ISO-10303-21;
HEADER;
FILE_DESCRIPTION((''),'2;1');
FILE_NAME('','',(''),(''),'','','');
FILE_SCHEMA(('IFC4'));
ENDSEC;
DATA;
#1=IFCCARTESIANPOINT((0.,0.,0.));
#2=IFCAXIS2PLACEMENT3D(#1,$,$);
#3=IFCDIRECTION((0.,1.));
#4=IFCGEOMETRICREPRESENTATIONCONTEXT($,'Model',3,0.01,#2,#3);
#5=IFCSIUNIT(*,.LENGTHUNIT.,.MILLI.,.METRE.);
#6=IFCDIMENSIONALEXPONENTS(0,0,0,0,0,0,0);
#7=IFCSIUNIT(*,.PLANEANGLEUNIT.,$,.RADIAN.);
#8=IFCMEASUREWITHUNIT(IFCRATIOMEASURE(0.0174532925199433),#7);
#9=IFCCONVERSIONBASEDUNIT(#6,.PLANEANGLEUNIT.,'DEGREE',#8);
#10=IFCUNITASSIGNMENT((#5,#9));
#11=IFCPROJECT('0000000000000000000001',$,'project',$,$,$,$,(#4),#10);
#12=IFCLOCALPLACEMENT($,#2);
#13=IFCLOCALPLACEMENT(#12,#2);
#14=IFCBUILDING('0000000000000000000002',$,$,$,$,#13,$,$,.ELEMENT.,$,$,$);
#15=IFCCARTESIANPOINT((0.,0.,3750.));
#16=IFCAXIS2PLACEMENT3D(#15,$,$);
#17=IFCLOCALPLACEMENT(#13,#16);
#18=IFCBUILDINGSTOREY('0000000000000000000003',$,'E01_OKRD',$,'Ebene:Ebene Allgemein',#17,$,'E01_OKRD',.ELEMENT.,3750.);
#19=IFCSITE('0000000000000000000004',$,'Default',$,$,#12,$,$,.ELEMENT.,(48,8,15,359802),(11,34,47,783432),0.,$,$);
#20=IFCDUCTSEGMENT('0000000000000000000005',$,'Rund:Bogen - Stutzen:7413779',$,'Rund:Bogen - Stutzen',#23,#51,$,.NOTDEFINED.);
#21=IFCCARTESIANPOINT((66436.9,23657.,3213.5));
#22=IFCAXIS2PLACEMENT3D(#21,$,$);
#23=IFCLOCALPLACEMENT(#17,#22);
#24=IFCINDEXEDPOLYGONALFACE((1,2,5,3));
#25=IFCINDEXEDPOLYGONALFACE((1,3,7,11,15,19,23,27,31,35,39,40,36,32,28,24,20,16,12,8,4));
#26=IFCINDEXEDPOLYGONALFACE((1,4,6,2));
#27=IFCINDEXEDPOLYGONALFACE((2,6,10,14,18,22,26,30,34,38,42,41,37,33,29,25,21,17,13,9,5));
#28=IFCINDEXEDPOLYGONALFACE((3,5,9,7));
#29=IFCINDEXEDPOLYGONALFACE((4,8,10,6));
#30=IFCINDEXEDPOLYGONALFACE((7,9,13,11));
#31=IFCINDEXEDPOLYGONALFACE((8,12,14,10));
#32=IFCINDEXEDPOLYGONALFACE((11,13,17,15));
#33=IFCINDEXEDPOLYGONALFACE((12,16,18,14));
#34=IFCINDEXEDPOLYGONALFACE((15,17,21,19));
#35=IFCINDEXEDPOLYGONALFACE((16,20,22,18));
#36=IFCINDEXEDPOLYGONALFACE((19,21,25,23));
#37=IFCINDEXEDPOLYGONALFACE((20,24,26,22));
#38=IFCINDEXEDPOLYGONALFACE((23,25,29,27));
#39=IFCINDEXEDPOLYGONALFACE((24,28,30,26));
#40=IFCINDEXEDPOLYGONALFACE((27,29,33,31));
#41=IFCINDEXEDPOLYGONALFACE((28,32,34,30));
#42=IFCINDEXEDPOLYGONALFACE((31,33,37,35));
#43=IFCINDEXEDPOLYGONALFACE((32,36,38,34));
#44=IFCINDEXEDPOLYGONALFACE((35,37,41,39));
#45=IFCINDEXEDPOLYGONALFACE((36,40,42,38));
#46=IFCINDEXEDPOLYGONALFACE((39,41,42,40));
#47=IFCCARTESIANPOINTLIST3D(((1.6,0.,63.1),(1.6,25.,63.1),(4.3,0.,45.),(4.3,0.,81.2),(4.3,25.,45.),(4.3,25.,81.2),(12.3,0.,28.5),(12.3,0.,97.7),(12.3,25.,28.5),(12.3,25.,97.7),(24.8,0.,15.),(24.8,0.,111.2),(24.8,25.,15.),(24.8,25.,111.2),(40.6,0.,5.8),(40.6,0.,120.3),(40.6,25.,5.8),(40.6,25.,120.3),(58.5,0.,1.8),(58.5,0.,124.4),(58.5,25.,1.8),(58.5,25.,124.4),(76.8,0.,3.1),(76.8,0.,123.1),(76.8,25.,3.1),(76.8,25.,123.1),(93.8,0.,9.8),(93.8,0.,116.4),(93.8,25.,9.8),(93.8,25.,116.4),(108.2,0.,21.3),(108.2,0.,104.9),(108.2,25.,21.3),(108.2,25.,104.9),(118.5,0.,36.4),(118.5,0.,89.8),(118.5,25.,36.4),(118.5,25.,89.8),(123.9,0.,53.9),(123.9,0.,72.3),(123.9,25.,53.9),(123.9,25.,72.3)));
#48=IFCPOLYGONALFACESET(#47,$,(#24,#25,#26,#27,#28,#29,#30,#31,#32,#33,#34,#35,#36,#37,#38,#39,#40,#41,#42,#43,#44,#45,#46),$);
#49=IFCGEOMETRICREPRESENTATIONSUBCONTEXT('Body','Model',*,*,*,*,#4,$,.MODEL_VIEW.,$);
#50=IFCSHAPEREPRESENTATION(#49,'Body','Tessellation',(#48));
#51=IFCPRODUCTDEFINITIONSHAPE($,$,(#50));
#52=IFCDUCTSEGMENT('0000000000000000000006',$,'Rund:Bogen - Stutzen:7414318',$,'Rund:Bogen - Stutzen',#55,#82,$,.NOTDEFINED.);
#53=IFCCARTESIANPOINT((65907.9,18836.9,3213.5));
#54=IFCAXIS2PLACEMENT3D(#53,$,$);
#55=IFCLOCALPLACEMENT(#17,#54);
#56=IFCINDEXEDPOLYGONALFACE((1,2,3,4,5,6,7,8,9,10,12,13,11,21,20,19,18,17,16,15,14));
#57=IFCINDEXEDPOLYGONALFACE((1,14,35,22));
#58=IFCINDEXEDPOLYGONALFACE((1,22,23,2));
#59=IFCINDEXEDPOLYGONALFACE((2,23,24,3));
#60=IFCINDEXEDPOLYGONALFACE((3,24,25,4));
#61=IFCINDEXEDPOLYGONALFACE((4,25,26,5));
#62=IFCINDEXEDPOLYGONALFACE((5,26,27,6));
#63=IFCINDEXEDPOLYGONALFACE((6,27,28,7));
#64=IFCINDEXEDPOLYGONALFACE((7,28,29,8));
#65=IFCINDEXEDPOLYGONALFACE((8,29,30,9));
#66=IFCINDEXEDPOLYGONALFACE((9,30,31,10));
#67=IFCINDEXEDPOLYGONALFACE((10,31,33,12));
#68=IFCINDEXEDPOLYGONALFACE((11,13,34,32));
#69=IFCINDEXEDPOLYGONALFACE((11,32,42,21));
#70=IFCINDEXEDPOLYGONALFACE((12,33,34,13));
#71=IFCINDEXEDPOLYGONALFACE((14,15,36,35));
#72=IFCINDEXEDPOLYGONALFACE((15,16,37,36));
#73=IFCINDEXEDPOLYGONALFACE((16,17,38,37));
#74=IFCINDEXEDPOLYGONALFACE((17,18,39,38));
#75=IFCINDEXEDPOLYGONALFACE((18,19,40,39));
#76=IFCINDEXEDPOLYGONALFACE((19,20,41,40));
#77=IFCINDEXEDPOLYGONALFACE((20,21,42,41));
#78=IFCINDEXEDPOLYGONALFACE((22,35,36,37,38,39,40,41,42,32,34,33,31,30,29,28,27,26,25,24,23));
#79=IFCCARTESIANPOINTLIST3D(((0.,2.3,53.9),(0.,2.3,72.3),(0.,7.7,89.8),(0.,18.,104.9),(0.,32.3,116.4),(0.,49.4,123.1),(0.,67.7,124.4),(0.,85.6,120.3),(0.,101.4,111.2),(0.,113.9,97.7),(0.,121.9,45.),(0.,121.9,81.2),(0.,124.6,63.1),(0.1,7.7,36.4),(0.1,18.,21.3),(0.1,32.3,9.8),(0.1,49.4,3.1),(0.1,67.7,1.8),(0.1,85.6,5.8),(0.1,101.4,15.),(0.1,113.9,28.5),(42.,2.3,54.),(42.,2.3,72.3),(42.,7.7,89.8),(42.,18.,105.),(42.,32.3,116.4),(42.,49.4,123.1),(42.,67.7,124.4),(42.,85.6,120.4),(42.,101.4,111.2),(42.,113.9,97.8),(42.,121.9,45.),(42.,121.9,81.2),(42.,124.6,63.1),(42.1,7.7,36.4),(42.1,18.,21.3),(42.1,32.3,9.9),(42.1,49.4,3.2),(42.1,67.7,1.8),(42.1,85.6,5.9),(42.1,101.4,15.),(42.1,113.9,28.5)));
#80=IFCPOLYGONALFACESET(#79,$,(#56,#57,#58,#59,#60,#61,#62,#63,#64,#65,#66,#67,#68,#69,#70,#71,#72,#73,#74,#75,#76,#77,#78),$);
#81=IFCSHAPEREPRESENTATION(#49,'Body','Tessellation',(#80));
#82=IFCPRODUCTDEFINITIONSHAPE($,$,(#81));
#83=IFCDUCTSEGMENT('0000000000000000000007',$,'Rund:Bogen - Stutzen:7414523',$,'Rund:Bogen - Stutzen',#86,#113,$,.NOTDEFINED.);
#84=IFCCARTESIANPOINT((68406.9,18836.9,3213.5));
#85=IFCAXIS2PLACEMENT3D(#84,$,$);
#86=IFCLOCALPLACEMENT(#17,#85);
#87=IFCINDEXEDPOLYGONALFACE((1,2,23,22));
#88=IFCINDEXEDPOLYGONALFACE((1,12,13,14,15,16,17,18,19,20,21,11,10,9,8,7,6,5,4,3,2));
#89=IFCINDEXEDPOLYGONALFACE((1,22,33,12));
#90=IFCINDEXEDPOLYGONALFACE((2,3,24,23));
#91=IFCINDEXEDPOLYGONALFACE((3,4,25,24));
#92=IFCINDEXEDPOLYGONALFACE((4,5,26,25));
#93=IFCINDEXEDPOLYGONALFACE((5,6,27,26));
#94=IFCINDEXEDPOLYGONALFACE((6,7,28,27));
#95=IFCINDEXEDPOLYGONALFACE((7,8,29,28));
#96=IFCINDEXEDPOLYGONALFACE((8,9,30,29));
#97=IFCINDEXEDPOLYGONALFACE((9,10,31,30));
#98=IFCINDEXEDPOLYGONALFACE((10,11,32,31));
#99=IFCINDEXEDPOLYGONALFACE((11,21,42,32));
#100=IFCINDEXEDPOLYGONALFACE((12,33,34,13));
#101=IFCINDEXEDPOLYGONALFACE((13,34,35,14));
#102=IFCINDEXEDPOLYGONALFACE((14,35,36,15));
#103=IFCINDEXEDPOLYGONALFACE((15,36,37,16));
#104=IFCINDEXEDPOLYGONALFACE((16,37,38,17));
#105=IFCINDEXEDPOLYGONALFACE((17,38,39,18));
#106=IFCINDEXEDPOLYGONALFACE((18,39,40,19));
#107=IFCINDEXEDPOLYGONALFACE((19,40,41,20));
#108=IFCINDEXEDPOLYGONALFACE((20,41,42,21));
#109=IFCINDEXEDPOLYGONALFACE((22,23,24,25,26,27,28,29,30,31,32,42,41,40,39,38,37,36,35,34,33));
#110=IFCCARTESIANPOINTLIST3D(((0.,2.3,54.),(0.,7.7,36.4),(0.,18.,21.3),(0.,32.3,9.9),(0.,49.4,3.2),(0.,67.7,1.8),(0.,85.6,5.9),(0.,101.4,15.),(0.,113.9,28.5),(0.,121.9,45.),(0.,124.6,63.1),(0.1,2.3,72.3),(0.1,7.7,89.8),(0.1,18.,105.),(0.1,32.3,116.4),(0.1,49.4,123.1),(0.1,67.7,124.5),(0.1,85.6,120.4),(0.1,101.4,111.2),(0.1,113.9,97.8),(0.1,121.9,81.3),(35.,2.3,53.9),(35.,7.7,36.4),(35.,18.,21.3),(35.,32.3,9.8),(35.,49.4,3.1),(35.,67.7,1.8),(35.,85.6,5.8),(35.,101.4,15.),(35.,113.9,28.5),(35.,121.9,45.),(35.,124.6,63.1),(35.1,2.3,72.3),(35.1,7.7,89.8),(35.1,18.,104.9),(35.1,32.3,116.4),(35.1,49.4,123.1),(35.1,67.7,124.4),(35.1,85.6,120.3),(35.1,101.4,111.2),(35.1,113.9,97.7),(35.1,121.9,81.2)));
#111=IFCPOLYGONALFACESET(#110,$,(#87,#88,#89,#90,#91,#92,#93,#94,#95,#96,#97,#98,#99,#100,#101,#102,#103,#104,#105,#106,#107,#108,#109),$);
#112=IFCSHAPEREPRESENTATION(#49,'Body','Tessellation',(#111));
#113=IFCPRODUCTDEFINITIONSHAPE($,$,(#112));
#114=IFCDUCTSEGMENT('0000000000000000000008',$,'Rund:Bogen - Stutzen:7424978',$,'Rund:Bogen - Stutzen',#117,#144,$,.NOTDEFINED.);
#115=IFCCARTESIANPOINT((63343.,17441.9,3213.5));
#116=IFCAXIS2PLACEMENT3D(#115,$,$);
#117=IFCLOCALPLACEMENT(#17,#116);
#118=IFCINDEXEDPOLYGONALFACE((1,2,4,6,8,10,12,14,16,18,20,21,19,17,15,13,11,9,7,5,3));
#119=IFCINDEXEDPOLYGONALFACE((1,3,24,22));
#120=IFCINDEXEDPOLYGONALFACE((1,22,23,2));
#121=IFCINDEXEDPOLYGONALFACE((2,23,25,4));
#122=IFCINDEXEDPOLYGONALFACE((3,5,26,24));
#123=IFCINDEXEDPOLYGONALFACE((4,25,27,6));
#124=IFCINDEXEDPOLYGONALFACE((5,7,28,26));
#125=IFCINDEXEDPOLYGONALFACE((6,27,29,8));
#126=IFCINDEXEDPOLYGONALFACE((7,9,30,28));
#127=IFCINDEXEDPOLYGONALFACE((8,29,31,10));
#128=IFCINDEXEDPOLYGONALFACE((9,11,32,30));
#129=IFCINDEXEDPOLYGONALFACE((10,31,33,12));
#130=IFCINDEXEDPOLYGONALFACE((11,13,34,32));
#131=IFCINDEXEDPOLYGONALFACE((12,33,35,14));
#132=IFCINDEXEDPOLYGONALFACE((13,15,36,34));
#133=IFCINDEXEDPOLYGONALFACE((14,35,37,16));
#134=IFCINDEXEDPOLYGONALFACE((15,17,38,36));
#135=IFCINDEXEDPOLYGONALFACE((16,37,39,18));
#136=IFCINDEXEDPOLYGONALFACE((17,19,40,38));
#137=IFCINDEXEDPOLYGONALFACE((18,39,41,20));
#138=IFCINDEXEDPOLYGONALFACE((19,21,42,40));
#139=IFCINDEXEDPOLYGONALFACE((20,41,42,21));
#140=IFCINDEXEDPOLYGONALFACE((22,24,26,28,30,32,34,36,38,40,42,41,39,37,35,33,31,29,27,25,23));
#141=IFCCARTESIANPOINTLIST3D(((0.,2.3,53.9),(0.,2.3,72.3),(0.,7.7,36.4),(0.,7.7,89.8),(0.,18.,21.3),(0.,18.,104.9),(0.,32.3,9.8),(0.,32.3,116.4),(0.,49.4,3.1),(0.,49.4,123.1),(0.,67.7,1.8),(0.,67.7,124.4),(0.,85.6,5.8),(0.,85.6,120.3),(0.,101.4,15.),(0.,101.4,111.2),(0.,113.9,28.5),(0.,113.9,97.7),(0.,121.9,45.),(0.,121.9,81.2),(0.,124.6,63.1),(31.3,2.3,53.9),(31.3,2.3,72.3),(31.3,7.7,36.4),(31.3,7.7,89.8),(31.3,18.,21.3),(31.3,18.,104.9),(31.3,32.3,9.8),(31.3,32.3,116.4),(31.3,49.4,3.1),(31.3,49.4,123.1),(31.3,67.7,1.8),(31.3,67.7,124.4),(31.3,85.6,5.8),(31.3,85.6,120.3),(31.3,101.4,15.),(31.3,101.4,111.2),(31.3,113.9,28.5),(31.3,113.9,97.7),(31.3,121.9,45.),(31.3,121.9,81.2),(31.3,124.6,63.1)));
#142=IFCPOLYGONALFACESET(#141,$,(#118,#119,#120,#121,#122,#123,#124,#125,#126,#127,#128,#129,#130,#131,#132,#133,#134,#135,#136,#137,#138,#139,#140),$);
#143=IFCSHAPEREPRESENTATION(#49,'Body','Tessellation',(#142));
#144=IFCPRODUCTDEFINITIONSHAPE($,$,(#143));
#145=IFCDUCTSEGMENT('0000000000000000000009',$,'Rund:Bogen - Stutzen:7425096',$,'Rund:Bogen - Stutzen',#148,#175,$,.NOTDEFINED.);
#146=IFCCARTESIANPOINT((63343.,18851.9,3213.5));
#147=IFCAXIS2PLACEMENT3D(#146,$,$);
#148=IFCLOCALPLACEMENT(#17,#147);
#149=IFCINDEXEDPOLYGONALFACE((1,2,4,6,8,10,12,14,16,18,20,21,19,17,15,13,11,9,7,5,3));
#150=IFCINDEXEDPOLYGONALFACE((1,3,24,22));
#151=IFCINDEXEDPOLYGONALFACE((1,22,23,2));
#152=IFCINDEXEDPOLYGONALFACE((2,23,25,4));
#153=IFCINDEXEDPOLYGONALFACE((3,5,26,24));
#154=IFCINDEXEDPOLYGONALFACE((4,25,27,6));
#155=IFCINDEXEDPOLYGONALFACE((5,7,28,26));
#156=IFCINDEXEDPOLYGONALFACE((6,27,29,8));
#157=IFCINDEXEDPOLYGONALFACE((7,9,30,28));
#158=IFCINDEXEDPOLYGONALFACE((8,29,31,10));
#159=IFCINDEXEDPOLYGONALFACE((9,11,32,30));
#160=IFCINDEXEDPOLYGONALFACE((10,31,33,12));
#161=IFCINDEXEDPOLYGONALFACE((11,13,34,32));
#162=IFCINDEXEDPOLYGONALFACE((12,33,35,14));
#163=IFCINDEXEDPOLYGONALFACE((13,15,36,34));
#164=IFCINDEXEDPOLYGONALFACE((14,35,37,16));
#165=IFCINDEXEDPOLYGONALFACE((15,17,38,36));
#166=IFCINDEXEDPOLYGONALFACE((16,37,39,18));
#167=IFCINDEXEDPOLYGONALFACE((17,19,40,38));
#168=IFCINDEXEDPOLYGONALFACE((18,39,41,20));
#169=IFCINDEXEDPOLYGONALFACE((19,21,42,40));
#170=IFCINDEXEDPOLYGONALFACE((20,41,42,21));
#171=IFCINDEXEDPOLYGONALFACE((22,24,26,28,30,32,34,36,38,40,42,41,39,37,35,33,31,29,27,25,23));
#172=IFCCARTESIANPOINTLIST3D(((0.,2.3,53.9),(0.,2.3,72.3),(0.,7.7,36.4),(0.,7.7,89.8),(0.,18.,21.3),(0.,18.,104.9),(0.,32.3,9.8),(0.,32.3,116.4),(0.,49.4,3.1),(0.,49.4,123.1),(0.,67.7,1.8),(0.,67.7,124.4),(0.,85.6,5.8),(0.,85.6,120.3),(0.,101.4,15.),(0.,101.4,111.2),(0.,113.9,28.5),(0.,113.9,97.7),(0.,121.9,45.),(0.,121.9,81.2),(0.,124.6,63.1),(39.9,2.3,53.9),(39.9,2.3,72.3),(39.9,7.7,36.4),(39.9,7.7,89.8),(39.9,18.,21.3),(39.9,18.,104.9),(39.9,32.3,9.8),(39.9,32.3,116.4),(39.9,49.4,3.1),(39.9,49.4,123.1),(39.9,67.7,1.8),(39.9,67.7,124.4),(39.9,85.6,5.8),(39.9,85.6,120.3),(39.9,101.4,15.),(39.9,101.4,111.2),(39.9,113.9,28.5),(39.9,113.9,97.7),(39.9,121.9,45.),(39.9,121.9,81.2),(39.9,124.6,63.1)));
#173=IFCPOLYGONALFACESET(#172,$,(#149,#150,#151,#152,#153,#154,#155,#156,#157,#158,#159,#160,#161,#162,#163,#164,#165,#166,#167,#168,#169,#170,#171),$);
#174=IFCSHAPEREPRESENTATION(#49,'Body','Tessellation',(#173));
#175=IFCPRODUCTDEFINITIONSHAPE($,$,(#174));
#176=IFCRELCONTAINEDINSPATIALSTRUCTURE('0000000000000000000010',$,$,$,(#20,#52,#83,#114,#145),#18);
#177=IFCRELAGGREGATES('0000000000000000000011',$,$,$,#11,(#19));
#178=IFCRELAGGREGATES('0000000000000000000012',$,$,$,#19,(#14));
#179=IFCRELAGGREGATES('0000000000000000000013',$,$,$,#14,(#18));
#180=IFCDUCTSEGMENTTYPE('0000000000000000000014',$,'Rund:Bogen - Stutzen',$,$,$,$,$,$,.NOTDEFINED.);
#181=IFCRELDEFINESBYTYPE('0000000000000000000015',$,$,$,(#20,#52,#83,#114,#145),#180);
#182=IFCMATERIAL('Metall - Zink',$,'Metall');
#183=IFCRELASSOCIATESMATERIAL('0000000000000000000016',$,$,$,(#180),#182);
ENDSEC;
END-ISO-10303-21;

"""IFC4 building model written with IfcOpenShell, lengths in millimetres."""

from ifc_helpers import new_model, entity, si_unit, converted_unit, direction, frame, frame_2d, origin, origin_2d_with_axis, place, context, subcontext, project, spatial, circle, extrude, material, type_object, element, save


model = new_model("IFC4")

# Units and contexts
model_context = context("Model", 3, precision=0.01, world=origin(), true_north=direction((0.0, 1.0)))
body_context = subcontext(model_context, "Body", "Model", "MODEL_VIEW")
ifc_project = project(units=[si_unit("LENGTHUNIT", "METRE", prefix="MILLI"), converted_unit("PLANEANGLEUNIT", "DEGREE", entity("IfcRatioMeasure", 0.0174532925199433), si_unit("PLANEANGLEUNIT", "RADIAN"), dimensions=[0, 0, 0, 0, 0, 0, 0])], contexts=[model_context])

# Site, building, storey
site_placement = place(None, origin())
site = spatial("IfcSite", under=ifc_project, at=site_placement, Name="Default", CompositionType="ELEMENT", RefLatitude=(48, 8, 15, 359802), RefLongitude=(11, 34, 47, 783432), RefElevation=0.0)
building_placement = place(site_placement, origin())
building = spatial("IfcBuilding", under=site, at=building_placement, CompositionType="ELEMENT")
storey_placement = place(building_placement, frame((0.0, 0.0, 3750.0)))
storey = spatial("IfcBuildingStorey", under=building, at=storey_placement, Name="E01_OKRD", ObjectType="Ebene:Ebene Allgemein", LongName="E01_OKRD", CompositionType="ELEMENT", Elevation=3750.0)

# Shared definitions
ifc_material_1 = material(Name="Metall - Zink", Category="Metall")

# Duct segments
duct_segment_type_1 = type_object("IfcDuctSegmentType", Name="Rund:Bogen - Stutzen", PredefinedType="NOTDEFINED", material=ifc_material_1)
duct_segment_1_placement = place(storey_placement, frame((66436.9, 23657.0, 3213.5)))
element("IfcDuctSegment", 1, at=duct_segment_1_placement, inside=storey, type_object=duct_segment_type_1, Name="Rund:Bogen - Stutzen:7413779", ObjectType="Rund:Bogen - Stutzen", PredefinedType="NOTDEFINED", context=body_context, shape_type="SweptSolid", body=[
    extrude(circle(Radius=61.5, at=frame_2d((0.0, 0.0), x_axis=(1.0, 0.0))), frame((63.1, 0.0, 63.1), z_axis=(0.0, 1.0, 0.0), x_axis=(-1.0, 0.0, 0.0)), (0.0, 0.0, 1.0), 25.0),
])
duct_segment_2_placement = place(storey_placement, frame((65907.9, 18836.9, 3213.5)))
element("IfcDuctSegment", 2, at=duct_segment_2_placement, inside=storey, type_object=duct_segment_type_1, Name="Rund:Bogen - Stutzen:7414318", ObjectType="Rund:Bogen - Stutzen", PredefinedType="NOTDEFINED", context=body_context, shape_type="SweptSolid", body=[
    extrude(circle(Radius=61.5, at=frame_2d((0.0, 0.0), x_axis=(1.0, 0.0))), frame((0.0, 63.1, 63.1), z_axis=(1.0, 0.0, 0.000613), x_axis=(0.0, 1.0, 0.0)), (0.0, 0.0, 1.0), 42.0),
])
duct_segment_3_placement = place(storey_placement, frame((68406.9, 18836.9, 3213.5)))
element("IfcDuctSegment", 3, at=duct_segment_3_placement, inside=storey, type_object=duct_segment_type_1, Name="Rund:Bogen - Stutzen:7414523", ObjectType="Rund:Bogen - Stutzen", PredefinedType="NOTDEFINED", context=body_context, shape_type="SweptSolid", body=[
    extrude(circle(Radius=61.5, at=origin_2d_with_axis()), frame((35.0, 63.1, 63.1), z_axis=(-1.0, 0.0, 0.000803), x_axis=(0.0, 1.0, 0.0)), (0.0, 0.0, 1.0), 35.0),
])
duct_segment_4_placement = place(storey_placement, frame((63343.0, 17441.9, 3213.5)))
element("IfcDuctSegment", 4, at=duct_segment_4_placement, inside=storey, type_object=duct_segment_type_1, Name="Rund:Bogen - Stutzen:7424978", ObjectType="Rund:Bogen - Stutzen", PredefinedType="NOTDEFINED", context=body_context, shape_type="SweptSolid", body=[
    extrude(circle(Radius=61.5, at=frame_2d((0.0, 0.0), x_axis=(1.0, 0.0))), frame((0.0, 63.1, 63.1), z_axis=(1.0, 0.0, 0.0), x_axis=(0.0, 1.0, 0.0)), (0.0, 0.0, 1.0), 31.3),
])
duct_segment_5_placement = place(storey_placement, frame((63343.0, 18851.9, 3213.5)))
element("IfcDuctSegment", 5, at=duct_segment_5_placement, inside=storey, type_object=duct_segment_type_1, Name="Rund:Bogen - Stutzen:7425096", ObjectType="Rund:Bogen - Stutzen", PredefinedType="NOTDEFINED", context=body_context, shape_type="SweptSolid", body=[
    extrude(circle(Radius=61.5, at=frame_2d((0.0, 0.0), x_axis=(1.0, 0.0))), frame((0.0, 63.1, 63.1), z_axis=(1.0, 0.0, 0.0), x_axis=(0.0, 1.0, 0.0)), (0.0, 0.0, 1.0), 39.9),
])

save(model, "model.ifc")
